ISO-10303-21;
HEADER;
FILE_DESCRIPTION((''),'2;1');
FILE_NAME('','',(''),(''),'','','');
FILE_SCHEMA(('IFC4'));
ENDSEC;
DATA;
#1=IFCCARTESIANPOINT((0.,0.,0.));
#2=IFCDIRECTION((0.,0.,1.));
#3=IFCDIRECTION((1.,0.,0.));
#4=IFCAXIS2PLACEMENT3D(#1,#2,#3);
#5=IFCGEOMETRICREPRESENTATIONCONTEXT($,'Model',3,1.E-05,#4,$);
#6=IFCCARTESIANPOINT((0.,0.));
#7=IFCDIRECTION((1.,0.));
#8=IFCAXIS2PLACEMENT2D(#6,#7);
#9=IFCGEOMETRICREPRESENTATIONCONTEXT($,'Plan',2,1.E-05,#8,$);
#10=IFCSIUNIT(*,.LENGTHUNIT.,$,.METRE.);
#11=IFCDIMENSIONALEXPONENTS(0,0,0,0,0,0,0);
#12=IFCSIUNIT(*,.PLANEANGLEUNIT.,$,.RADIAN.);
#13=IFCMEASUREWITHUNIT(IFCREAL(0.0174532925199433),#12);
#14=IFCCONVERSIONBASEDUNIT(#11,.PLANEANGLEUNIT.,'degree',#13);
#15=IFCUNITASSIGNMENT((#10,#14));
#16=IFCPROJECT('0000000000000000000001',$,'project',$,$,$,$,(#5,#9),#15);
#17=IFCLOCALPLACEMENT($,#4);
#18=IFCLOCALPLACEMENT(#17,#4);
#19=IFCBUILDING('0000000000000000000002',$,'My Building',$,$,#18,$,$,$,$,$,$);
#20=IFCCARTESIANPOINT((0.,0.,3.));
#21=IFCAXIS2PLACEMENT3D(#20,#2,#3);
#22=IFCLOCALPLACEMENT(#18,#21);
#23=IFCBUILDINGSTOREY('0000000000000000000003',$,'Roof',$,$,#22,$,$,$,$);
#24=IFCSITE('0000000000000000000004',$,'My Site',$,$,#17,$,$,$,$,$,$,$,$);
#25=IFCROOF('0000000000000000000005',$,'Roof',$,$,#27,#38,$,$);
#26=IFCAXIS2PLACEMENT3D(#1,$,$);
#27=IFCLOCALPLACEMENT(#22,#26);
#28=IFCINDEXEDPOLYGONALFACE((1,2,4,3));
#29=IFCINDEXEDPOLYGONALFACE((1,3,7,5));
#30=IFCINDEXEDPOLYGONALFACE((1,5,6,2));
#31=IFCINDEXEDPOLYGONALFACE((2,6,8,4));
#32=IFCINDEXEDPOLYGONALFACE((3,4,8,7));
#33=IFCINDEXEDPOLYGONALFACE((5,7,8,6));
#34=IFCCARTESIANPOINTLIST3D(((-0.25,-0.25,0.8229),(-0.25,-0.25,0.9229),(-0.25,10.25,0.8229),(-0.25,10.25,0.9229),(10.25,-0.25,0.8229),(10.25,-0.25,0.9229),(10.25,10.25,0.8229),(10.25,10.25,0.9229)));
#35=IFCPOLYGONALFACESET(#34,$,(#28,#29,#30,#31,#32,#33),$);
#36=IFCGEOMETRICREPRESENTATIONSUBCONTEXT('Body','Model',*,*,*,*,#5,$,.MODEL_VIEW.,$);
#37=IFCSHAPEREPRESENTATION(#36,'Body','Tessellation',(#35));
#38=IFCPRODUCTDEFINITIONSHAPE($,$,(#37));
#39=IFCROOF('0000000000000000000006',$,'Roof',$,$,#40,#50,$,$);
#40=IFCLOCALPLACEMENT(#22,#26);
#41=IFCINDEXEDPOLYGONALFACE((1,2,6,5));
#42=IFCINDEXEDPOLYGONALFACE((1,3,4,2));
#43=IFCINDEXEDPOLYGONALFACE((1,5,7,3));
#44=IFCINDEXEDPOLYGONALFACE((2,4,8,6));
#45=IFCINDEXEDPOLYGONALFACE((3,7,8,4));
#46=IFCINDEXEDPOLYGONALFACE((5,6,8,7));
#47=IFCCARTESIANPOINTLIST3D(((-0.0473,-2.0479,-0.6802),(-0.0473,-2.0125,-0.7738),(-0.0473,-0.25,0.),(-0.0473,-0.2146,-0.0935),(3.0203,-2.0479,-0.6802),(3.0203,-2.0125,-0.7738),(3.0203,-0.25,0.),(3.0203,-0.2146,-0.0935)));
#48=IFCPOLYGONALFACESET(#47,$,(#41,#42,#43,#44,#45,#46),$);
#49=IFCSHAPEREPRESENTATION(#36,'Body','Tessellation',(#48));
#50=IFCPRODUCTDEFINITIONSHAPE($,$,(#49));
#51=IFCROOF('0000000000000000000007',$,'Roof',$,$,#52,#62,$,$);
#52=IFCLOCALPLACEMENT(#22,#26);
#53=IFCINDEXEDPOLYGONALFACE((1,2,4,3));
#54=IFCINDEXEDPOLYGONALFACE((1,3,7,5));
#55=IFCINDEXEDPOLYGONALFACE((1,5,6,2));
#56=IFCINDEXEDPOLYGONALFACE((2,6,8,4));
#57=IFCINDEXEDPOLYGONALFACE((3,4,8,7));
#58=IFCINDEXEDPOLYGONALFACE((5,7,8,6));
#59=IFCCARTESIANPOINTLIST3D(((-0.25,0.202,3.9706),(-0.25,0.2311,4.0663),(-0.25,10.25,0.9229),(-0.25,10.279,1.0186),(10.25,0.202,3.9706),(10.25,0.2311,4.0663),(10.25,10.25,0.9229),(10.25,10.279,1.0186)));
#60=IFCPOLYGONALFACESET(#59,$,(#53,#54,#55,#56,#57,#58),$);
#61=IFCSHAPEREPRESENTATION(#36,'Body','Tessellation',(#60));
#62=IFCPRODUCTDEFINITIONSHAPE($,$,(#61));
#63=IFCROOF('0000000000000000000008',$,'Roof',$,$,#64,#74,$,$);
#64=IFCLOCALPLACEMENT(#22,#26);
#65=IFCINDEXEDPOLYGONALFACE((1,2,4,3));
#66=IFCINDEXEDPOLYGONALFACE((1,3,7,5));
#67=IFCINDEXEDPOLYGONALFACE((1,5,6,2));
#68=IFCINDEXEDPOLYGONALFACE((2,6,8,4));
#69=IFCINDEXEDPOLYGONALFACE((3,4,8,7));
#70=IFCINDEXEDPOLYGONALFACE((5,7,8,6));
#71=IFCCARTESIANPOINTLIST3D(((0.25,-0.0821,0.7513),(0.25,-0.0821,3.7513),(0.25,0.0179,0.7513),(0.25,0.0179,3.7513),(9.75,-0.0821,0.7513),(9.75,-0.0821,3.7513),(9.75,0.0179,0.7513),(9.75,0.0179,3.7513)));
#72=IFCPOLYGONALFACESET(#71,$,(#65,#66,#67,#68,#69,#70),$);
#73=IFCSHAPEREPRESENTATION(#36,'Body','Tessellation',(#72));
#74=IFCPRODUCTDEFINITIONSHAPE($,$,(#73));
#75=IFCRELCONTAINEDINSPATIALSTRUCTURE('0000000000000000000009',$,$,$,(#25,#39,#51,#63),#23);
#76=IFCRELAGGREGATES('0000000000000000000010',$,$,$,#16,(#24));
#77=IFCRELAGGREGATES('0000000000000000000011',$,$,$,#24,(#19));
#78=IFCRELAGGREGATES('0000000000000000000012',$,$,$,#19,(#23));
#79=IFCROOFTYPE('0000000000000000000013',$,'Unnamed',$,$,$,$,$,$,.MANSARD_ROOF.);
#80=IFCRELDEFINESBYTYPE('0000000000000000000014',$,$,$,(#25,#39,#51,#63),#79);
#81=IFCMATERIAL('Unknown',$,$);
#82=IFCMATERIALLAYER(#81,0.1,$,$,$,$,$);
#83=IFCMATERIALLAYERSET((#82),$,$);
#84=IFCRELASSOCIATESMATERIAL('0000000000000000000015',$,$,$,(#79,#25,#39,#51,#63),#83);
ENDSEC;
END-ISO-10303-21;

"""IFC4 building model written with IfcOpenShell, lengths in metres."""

from ifc_helpers import new_model, entity, si_unit, converted_unit, frame, origin_with_axes, origin_2d_with_axis, place, context, subcontext, project, spatial, indexed_curve, outline, extrude, material, layer, layer_set, layer_usage, type_object, element, save


model = new_model("IFC4")

# Units and contexts
model_context = context("Model", 3, precision=1e-05, world=origin_with_axes())
plan_context = context("Plan", 2, precision=1e-05, world=origin_2d_with_axis())
body_context = subcontext(model_context, "Body", "Model", "MODEL_VIEW")
ifc_project = project(units=[si_unit("LENGTHUNIT", "METRE"), converted_unit("PLANEANGLEUNIT", "degree", entity("IfcReal", 0.0174532925199433), si_unit("PLANEANGLEUNIT", "RADIAN"), dimensions=[0, 0, 0, 0, 0, 0, 0])], contexts=[model_context, plan_context])

# Site, building, storey
site_placement = place(None, origin_with_axes())
site = spatial("IfcSite", under=ifc_project, at=site_placement, Name="My Site")
building_placement = place(site_placement, origin_with_axes())
building = spatial("IfcBuilding", under=site, at=building_placement, Name="My Building")
storey_placement = place(building_placement, frame((0.0, 0.0, 3.0), z_axis=(0.0, 0.0, 1.0), x_axis=(1.0, 0.0, 0.0)))
storey = spatial("IfcBuildingStorey", under=building, at=storey_placement, Name="Roof")

# Roofs
ifc_material = material(Name="Unknown")
ifc_layer = layer(ifc_material, 0.1)
ifc_layer_set = layer_set([ifc_layer])
ifc_layer_usage_1 = layer_usage(ifc_layer_set, "AXIS3", "POSITIVE", -0.1)
roof_type = type_object("IfcRoofType", Name="Unnamed", PredefinedType="MANSARD_ROOF", material=ifc_layer_set)
roof_1_placement = place(storey_placement, frame((-0.25, 10.25, 0.9229), z_axis=(0.0, 0.0, 1.0), x_axis=(1.0, 0.0, 0.0)))
element("IfcRoof", 1, at=roof_1_placement, inside=storey, type_object=roof_type, material=ifc_layer_usage_1, Name="Roof", context=body_context, shape_type="SweptSolid", body=[
    extrude(outline(indexed_curve([(0.0, 0.0), (10.5, 0.0), (10.5, -10.5), (0.0, -10.5), (0.0, 0.0)])), frame((0.0, 0.0, -0.1), z_axis=(0.0, 0.0, 1.0), x_axis=(1.0, 0.0, 0.0)), (0.0, 0.0, 1.0), 0.1),
])
ifc_layer_usage_2 = layer_usage(ifc_layer_set, "AXIS3", "POSITIVE", -0.1)
roof_2_placement = place(storey_placement, frame((-0.0473, -0.25, 0.0), z_axis=(0.0, -0.353878, 0.935292), x_axis=(1.0, 0.0, 0.0)))
element("IfcRoof", 2, at=roof_2_placement, inside=storey, type_object=roof_type, material=ifc_layer_usage_2, Name="Roof", context=body_context, shape_type="SweptSolid", body=[
    extrude(outline(indexed_curve([(0.0, 0.0), (0.0, -1.9222), (3.0676, -1.9222), (3.0676, 0.0), (0.0, 0.0)])), frame((0.0, 0.0, -0.1), z_axis=(0.0, 0.0, 1.0), x_axis=(1.0, 0.0, 0.0)), (0.0, 0.0, 1.0), 0.1),
])
ifc_layer_usage_3 = layer_usage(ifc_layer_set, "AXIS3", "POSITIVE", -0.1)
roof_3_placement = place(storey_placement, frame((-0.25, 10.279, 1.0186), z_axis=(0.0, 0.29026, 0.956948), x_axis=(1.0, 0.0, 0.0)))
element("IfcRoof", 3, at=roof_3_placement, inside=storey, type_object=roof_type, material=ifc_layer_usage_3, Name="Roof", context=body_context, shape_type="SweptSolid", body=[
    extrude(outline(indexed_curve([(0.0, 0.0), (10.5, 0.0), (10.5, -10.5), (0.0, -10.5), (0.0, 0.0)])), frame((0.0, 0.0, -0.1), z_axis=(0.0, 0.0, 1.0), x_axis=(1.0, 0.0, 0.0)), (0.0, 0.0, 1.0), 0.1),
])
ifc_layer_usage_4 = layer_usage(ifc_layer_set, "AXIS3", "POSITIVE", -0.1)
roof_4_placement = place(storey_placement, frame((0.25, -0.0821, 3.7513), z_axis=(0.0, -1.0, 0.0), x_axis=(1.0, 0.0, 0.0)))
element("IfcRoof", 4, at=roof_4_placement, inside=storey, type_object=roof_type, material=ifc_layer_usage_4, Name="Roof", context=body_context, shape_type="SweptSolid", body=[
    extrude(outline(indexed_curve([(0.0, 0.0), (9.5, 0.0), (9.5, -3.0), (0.0, -3.0), (0.0, 0.0)])), frame((0.0, 0.0, -0.1), z_axis=(0.0, 0.0, 1.0), x_axis=(1.0, 0.0, 0.0)), (0.0, 0.0, 1.0), 0.1),
])

save(model, "model.ifc")
